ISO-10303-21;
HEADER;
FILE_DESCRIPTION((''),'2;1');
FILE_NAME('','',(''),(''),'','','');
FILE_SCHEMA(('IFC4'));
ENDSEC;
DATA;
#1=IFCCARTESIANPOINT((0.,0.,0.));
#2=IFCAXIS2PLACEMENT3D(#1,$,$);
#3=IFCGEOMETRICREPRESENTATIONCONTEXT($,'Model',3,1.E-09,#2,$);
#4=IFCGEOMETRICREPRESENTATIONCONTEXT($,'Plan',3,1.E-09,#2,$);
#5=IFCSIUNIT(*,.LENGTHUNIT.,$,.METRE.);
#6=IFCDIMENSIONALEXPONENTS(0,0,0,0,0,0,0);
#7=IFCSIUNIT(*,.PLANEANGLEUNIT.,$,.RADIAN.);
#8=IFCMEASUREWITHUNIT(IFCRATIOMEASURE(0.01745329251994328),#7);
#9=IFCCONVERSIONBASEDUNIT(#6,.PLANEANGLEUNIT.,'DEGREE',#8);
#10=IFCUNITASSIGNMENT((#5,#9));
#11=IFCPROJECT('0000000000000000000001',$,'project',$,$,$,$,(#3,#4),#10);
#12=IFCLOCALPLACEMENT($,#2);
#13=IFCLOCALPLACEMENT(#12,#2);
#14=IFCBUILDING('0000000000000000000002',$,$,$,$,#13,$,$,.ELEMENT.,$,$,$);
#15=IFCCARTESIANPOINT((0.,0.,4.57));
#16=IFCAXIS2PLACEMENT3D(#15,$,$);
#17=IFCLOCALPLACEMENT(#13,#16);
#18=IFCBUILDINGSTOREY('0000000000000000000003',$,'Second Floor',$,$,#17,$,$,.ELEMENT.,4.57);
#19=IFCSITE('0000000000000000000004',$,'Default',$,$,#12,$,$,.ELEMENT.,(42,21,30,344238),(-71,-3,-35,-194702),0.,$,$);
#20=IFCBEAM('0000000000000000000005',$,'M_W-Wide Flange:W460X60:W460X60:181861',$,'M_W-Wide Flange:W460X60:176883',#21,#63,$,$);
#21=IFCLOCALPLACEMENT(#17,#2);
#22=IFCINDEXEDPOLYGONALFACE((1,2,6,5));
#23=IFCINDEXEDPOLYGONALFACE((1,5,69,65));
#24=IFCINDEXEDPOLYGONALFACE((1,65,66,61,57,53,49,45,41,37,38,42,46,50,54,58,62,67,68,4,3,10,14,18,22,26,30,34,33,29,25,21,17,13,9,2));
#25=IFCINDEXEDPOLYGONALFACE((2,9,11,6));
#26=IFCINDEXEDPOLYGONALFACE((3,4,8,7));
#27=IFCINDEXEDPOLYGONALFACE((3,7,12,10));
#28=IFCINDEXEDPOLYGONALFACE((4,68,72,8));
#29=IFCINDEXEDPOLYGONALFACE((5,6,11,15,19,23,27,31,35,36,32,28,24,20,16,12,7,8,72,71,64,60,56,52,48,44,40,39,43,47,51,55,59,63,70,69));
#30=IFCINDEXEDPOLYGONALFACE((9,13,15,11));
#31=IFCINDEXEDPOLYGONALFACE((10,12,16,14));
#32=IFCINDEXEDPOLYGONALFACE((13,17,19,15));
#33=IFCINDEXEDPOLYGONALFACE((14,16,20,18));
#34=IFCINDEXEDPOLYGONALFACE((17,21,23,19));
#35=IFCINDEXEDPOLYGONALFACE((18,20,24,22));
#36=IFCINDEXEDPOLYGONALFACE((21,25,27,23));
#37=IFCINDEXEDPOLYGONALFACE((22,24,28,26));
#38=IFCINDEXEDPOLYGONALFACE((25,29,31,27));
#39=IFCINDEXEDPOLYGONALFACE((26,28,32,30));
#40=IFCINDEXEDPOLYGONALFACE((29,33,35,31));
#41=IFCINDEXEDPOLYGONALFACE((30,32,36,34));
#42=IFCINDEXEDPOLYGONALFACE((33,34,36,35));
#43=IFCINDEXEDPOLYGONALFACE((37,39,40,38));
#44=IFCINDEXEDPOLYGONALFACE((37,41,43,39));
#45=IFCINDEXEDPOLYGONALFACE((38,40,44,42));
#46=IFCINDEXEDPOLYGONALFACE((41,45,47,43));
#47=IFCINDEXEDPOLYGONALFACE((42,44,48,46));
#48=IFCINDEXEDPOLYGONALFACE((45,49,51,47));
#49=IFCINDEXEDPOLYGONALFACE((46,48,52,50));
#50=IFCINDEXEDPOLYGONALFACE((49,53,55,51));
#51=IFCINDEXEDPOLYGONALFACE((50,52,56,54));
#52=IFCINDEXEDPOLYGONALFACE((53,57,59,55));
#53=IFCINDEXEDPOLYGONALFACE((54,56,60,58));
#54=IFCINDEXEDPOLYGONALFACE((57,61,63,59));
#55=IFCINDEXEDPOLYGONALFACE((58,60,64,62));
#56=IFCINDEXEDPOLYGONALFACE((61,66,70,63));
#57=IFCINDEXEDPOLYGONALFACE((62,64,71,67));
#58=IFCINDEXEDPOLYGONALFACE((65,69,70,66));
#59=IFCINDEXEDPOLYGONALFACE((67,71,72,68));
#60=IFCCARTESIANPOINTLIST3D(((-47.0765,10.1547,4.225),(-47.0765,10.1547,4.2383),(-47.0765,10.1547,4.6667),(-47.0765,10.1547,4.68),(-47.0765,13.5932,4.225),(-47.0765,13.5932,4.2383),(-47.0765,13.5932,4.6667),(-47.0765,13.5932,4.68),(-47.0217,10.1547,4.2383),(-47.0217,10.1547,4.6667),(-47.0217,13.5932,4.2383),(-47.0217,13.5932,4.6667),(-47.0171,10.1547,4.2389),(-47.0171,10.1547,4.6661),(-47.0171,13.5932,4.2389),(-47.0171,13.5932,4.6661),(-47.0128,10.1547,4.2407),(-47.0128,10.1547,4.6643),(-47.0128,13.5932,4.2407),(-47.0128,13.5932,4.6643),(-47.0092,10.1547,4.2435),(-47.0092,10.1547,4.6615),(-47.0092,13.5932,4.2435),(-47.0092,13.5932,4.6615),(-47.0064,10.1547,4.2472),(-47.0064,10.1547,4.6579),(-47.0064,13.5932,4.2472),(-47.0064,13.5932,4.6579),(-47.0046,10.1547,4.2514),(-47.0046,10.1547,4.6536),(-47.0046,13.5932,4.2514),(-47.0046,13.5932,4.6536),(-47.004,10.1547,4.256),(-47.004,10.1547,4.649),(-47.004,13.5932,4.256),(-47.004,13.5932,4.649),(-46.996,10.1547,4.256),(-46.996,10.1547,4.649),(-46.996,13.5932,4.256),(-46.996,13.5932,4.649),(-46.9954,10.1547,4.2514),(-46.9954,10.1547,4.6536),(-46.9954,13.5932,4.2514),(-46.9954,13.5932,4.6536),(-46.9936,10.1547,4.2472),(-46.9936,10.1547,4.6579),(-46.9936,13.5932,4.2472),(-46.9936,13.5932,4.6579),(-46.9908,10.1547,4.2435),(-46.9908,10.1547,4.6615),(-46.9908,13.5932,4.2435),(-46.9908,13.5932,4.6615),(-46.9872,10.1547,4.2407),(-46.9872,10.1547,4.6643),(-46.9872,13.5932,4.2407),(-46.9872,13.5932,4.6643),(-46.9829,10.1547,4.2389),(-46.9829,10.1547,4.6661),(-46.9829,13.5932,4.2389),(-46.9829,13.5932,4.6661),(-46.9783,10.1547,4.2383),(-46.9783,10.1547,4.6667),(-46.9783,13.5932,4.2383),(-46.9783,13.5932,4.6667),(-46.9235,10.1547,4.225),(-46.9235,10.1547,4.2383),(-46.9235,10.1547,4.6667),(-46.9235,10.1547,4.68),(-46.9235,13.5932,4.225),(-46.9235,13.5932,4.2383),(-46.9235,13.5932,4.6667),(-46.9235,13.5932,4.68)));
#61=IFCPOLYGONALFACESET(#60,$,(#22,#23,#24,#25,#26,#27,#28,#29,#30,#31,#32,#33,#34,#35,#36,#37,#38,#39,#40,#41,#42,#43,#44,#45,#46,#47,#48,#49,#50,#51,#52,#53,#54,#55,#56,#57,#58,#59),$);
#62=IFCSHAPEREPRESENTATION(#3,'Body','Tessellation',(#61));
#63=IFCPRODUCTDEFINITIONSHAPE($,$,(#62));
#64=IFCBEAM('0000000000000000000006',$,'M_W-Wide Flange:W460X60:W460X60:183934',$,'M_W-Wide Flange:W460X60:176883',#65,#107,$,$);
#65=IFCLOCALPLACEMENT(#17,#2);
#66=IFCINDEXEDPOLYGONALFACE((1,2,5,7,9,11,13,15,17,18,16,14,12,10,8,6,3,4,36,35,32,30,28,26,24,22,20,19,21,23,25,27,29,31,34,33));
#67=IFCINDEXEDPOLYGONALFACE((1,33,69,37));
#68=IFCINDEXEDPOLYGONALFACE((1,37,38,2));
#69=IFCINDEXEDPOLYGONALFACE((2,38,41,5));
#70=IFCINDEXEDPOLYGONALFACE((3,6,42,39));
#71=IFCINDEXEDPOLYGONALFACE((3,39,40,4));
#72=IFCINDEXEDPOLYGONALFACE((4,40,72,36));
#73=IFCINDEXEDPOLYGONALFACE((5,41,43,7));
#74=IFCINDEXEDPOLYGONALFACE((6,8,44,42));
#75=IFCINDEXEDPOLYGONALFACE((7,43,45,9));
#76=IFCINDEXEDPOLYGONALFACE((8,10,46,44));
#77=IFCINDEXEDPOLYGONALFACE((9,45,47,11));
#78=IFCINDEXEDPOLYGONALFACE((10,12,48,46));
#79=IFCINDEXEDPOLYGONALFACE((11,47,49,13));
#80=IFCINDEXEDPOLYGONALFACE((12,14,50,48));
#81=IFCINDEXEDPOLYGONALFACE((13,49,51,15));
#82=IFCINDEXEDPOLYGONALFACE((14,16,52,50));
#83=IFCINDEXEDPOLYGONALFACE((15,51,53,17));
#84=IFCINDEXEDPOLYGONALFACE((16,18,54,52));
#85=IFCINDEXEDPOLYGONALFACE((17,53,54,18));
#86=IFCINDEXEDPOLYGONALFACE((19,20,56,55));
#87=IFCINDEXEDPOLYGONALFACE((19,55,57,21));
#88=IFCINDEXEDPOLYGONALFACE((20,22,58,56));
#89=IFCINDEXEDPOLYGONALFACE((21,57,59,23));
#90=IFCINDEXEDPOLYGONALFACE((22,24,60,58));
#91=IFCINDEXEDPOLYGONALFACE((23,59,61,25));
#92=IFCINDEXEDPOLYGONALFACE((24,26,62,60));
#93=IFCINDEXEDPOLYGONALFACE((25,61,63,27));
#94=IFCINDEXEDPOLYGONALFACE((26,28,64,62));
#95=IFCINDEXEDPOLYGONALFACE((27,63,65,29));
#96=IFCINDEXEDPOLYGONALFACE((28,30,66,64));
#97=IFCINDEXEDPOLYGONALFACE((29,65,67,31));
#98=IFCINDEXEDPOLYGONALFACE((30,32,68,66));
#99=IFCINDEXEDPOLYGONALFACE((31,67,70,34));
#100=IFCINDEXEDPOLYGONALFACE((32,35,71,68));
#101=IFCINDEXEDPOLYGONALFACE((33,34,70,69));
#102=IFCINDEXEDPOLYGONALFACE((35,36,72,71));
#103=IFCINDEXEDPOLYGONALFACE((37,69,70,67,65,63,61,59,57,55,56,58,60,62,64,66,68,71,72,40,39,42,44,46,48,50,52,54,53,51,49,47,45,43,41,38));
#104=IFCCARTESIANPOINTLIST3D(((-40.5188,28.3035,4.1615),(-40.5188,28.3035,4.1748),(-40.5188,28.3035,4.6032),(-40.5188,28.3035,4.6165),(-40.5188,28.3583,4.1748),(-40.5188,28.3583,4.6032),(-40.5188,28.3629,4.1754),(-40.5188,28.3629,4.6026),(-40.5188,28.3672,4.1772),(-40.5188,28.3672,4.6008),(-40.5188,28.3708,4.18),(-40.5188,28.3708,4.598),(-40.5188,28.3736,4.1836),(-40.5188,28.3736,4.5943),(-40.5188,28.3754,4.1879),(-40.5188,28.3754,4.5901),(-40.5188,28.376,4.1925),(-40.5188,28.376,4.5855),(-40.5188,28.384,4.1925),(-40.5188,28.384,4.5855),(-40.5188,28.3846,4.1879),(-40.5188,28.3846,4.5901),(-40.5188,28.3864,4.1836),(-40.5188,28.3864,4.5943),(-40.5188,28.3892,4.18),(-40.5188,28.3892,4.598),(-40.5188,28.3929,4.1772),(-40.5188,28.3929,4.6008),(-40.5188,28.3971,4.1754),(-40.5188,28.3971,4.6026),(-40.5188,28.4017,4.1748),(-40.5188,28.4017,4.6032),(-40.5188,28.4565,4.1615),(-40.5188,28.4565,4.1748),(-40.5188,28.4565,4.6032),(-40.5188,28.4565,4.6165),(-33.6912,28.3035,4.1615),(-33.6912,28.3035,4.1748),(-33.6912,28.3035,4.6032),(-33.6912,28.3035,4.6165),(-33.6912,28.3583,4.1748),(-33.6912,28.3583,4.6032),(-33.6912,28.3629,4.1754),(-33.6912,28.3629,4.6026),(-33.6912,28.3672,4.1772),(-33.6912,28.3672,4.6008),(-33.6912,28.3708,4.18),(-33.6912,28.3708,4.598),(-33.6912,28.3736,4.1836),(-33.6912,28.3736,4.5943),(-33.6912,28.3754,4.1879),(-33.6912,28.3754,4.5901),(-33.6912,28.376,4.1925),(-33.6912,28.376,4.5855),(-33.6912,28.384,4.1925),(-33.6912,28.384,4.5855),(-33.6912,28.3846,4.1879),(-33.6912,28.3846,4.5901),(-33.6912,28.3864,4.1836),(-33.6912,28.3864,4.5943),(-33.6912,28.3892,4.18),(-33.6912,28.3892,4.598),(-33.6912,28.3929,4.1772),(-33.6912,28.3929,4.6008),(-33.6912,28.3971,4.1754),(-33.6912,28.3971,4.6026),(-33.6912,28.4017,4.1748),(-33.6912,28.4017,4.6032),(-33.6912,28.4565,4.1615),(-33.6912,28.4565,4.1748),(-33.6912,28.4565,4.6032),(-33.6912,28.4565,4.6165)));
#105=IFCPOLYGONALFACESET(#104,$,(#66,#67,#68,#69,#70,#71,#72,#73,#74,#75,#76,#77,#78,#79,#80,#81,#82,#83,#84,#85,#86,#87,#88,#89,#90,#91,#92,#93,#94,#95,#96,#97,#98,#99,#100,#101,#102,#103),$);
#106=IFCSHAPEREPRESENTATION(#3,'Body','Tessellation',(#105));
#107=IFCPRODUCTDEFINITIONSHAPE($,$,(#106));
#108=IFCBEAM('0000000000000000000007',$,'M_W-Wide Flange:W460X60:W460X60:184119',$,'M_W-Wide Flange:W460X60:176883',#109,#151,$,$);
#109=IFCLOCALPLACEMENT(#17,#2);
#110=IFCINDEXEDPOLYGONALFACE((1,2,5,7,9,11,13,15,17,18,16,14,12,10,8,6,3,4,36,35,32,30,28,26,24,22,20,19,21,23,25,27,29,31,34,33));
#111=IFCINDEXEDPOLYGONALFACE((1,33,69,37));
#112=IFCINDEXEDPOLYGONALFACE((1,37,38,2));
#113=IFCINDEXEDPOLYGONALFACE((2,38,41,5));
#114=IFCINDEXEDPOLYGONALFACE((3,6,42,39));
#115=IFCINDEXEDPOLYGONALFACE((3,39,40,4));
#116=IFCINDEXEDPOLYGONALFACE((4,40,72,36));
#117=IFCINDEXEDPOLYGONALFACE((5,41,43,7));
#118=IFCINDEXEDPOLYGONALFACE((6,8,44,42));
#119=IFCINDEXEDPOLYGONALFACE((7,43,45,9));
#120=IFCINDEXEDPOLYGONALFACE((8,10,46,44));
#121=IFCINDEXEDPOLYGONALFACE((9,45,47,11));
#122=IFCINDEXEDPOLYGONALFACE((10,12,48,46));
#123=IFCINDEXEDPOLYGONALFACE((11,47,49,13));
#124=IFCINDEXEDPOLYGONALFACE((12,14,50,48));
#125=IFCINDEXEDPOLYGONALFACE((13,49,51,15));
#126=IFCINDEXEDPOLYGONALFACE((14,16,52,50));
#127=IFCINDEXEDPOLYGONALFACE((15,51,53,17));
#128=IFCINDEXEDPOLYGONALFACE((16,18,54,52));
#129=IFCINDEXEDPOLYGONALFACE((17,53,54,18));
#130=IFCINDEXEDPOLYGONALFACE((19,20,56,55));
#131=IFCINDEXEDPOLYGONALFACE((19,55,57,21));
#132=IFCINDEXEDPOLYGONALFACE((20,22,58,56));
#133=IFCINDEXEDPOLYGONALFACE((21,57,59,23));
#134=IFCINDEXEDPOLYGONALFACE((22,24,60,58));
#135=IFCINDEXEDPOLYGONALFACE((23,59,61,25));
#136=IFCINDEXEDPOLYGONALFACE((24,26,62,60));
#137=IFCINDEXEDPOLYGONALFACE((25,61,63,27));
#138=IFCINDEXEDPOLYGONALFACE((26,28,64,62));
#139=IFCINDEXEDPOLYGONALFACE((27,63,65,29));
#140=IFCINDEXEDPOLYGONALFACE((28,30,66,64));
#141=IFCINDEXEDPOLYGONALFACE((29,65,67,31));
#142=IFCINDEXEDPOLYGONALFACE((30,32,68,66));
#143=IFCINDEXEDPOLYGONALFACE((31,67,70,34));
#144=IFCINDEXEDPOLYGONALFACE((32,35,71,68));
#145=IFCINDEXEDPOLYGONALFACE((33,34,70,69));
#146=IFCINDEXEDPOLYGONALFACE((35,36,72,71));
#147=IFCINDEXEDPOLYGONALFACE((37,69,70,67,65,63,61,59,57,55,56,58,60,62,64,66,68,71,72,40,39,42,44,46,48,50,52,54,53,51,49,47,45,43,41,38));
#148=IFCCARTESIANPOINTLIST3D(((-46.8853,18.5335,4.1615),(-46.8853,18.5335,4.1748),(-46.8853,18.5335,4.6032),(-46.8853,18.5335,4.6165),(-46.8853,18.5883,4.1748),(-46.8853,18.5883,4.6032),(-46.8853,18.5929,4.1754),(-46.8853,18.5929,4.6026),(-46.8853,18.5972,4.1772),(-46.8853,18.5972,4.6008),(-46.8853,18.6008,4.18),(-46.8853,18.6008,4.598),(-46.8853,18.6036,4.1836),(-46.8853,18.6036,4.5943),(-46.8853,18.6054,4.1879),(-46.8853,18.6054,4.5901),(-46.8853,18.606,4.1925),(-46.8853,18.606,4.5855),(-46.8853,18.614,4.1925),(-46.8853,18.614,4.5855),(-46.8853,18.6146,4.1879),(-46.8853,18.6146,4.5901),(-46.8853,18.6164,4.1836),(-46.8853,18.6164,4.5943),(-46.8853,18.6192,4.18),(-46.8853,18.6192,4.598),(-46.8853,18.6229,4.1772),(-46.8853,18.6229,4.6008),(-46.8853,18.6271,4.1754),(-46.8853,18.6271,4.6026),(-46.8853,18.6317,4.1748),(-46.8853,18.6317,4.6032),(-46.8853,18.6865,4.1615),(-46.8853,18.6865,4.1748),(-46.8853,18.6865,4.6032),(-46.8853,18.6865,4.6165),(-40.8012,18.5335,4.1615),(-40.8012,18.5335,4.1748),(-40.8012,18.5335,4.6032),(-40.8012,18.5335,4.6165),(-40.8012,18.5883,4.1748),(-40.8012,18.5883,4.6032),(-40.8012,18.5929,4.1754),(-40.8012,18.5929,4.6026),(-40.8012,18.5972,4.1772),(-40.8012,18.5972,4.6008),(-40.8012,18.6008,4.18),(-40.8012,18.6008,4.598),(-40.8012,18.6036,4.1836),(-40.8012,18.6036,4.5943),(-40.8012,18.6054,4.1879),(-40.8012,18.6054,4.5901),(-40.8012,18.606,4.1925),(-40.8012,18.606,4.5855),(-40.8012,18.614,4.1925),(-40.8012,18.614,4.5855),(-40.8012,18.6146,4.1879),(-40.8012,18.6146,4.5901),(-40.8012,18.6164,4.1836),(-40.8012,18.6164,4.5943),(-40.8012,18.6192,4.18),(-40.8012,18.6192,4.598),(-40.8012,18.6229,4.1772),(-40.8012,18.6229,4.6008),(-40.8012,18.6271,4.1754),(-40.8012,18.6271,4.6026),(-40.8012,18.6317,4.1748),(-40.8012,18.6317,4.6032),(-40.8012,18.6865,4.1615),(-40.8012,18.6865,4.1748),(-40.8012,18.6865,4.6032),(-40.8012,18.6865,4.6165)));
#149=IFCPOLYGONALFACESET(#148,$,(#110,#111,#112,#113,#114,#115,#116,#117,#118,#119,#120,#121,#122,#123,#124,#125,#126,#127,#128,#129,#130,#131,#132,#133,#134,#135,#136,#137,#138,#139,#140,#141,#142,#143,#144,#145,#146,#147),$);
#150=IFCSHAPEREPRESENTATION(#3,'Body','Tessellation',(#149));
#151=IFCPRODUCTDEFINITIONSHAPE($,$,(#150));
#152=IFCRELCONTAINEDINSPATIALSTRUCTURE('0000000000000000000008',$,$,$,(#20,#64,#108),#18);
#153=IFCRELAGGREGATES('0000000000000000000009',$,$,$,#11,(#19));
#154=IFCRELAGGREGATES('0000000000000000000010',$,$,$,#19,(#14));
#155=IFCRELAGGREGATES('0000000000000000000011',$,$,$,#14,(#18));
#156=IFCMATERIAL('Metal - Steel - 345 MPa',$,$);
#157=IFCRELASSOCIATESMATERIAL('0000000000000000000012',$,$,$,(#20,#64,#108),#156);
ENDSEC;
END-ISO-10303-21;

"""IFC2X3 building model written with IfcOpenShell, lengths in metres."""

from ifc_helpers import new_model, entity, si_unit, converted_unit, frame, frame_2d, origin, place, context, project, spatial, polyline, circle_curve, parameter, trimmed, segment, composite_curve, outline, extrude, material, element, save


model = new_model("IFC2X3")

# Units and contexts
model_context = context("Model", 3, precision=1e-09, world=origin())
plan_context = context("Plan", 3, precision=1e-09, world=origin())
ifc_project = project(units=[si_unit("LENGTHUNIT", "METRE"), converted_unit("PLANEANGLEUNIT", "DEGREE", entity("IfcRatioMeasure", 0.01745329251994328), si_unit("PLANEANGLEUNIT", "RADIAN"), dimensions=[0, 0, 0, 0, 0, 0, 0])], contexts=[model_context, plan_context])

# Site, building, storey
site_placement = place(None, origin())
site = spatial("IfcSite", under=ifc_project, at=site_placement, Name="Default", CompositionType="ELEMENT", RefLatitude=(42, 21, 30, 344238), RefLongitude=(-71, -3, -35, -194702), RefElevation=0.0)
building_placement = place(site_placement, origin())
building = spatial("IfcBuilding", under=site, at=building_placement, CompositionType="ELEMENT")
storey_placement = place(building_placement, frame((0.0, 0.0, 4.57)))
storey = spatial("IfcBuildingStorey", under=building, at=storey_placement, Name="Second Floor", CompositionType="ELEMENT", Elevation=4.57)

# Shared definitions
ifc_material_1 = material(Name="Metal - Steel - 345 MPa")

# Beams
beam_1_placement = place(storey_placement, frame((-47.0, 13.7293, 4.68), z_axis=(0.0, 0.0, 1.0), x_axis=(-1.0, 0.0, 0.0)))
element("IfcBeam", 1, at=beam_1_placement, inside=storey, material=ifc_material_1, Name="M_W-Wide Flange:W460X60:W460X60:181861", ObjectType="M_W-Wide Flange:W460X60:176883", context=model_context, shape_type="SweptSolid", body=[
    extrude(outline(composite_curve([segment(polyline([(0.2142, -0.0765), (0.2275, -0.0765)]), True, "CONTINUOUS"), segment(polyline([(0.2275, -0.0765), (0.2275, 0.0765)]), True, "CONTINUOUS"), segment(polyline([(0.2275, 0.0765), (0.2142, 0.0765)]), True, "CONTINUOUS"), segment(polyline([(0.2142, 0.0765), (0.2142, 0.0217)]), True, "CONTINUOUS"), segment(trimmed(circle_curve(frame_2d((0.1965, 0.0217), x_axis=(0.0, 1.0)), 0.0177), [parameter(180.0)], [parameter(270.0)], True, "PARAMETER"), False, "CONTINUOUS"), segment(polyline([(0.1965, 0.004), (-0.1965, 0.004)]), True, "CONTINUOUS"), segment(trimmed(circle_curve(frame_2d((-0.1965, 0.0217), x_axis=(0.0, 1.0)), 0.0177), [parameter(90.0)], [parameter(180.0)], True, "PARAMETER"), False, "CONTINUOUS"), segment(polyline([(-0.2142, 0.0217), (-0.2142, 0.0765)]), True, "CONTINUOUS"), segment(polyline([(-0.2142, 0.0765), (-0.2275, 0.0765)]), True, "CONTINUOUS"), segment(polyline([(-0.2275, 0.0765), (-0.2275, -0.0765)]), True, "CONTINUOUS"), segment(polyline([(-0.2275, -0.0765), (-0.2142, -0.0765)]), True, "CONTINUOUS"), segment(polyline([(-0.2142, -0.0765), (-0.2142, -0.0217)]), True, "CONTINUOUS"), segment(trimmed(circle_curve(frame_2d((-0.1965, -0.0217), x_axis=(0.0, 1.0)), 0.0177), [parameter(360.0)], [parameter(90.0)], True, "PARAMETER"), False, "CONTINUOUS"), segment(polyline([(-0.1965, -0.004), (0.1965, -0.004)]), True, "CONTINUOUS"), segment(trimmed(circle_curve(frame_2d((0.1965, -0.0217), x_axis=(0.0, 1.0)), 0.0177), [parameter(270.0)], [parameter(0.0)], True, "PARAMETER"), False, "CONTINUOUS"), segment(polyline([(0.2142, -0.0217), (0.2142, -0.0765)]), True, "CONTINUOUS")], self_intersect=False)), frame((0.0, 3.5746, -0.2275), z_axis=(0.0, -1.0, 0.0), x_axis=(0.0, 0.0, -1.0)), (0.0, 0.0, 1.0), 3.4385),
])
beam_2_placement = place(storey_placement, frame((-40.6573, 28.38, 4.6165), z_axis=(0.0, 0.0, 1.0), x_axis=(0.0, -1.0, 0.0)))
element("IfcBeam", 2, at=beam_2_placement, inside=storey, material=ifc_material_1, Name="M_W-Wide Flange:W460X60:W460X60:183934", ObjectType="M_W-Wide Flange:W460X60:176883", context=model_context, shape_type="SweptSolid", body=[
    extrude(outline(composite_curve([segment(polyline([(-0.0765, -0.2142), (-0.0765, -0.2275)]), True, "CONTINUOUS"), segment(polyline([(-0.0765, -0.2275), (0.0765, -0.2275)]), True, "CONTINUOUS"), segment(polyline([(0.0765, -0.2275), (0.0765, -0.2142)]), True, "CONTINUOUS"), segment(polyline([(0.0765, -0.2142), (0.0217, -0.2142)]), True, "CONTINUOUS"), segment(trimmed(circle_curve(frame_2d((0.0217, -0.1965), x_axis=(0.0, -1.0)), 0.0177), [parameter(270.0)], [parameter(360.0)], True, "PARAMETER"), False, "CONTINUOUS"), segment(polyline([(0.004, -0.1965), (0.004, 0.1965)]), True, "CONTINUOUS"), segment(trimmed(circle_curve(frame_2d((0.0217, 0.1965), x_axis=(-1.0, 0.0)), 0.0177), [parameter(270.0)], [parameter(360.0)], True, "PARAMETER"), False, "CONTINUOUS"), segment(polyline([(0.0217, 0.2142), (0.0765, 0.2142)]), True, "CONTINUOUS"), segment(polyline([(0.0765, 0.2142), (0.0765, 0.2275)]), True, "CONTINUOUS"), segment(polyline([(0.0765, 0.2275), (-0.0765, 0.2275)]), True, "CONTINUOUS"), segment(polyline([(-0.0765, 0.2275), (-0.0765, 0.2142)]), True, "CONTINUOUS"), segment(polyline([(-0.0765, 0.2142), (-0.0217, 0.2142)]), True, "CONTINUOUS"), segment(trimmed(circle_curve(frame_2d((-0.0217, 0.1965), x_axis=(0.0, 1.0)), 0.0177), [parameter(270.0)], [parameter(360.0)], True, "PARAMETER"), False, "CONTINUOUS"), segment(polyline([(-0.004, 0.1965), (-0.004, -0.1965)]), True, "CONTINUOUS"), segment(trimmed(circle_curve(frame_2d((-0.0217, -0.1965), x_axis=(1.0, 0.0)), 0.0177), [parameter(270.0)], [parameter(0.0)], True, "PARAMETER"), False, "CONTINUOUS"), segment(polyline([(-0.0217, -0.2142), (-0.0765, -0.2142)]), True, "CONTINUOUS")], self_intersect=False)), frame((0.0, 0.1385, -0.2275), z_axis=(0.0, -1.0, 0.0), x_axis=(1.0, 0.0, 0.0)), (0.0, 0.0, -1.0), 6.8276),
])
beam_3_placement = place(storey_placement, frame((-40.663, 18.61, 4.6165), z_axis=(0.0, 0.0, 1.0), x_axis=(0.0, 1.0, 0.0)))
element("IfcBeam", 3, at=beam_3_placement, inside=storey, material=ifc_material_1, Name="M_W-Wide Flange:W460X60:W460X60:184119", ObjectType="M_W-Wide Flange:W460X60:176883", context=model_context, shape_type="SweptSolid", body=[
    extrude(outline(composite_curve([segment(polyline([(0.2142, -0.0765), (0.2275, -0.0765)]), True, "CONTINUOUS"), segment(polyline([(0.2275, -0.0765), (0.2275, 0.0765)]), True, "CONTINUOUS"), segment(polyline([(0.2275, 0.0765), (0.2142, 0.0765)]), True, "CONTINUOUS"), segment(polyline([(0.2142, 0.0765), (0.2142, 0.0217)]), True, "CONTINUOUS"), segment(trimmed(circle_curve(frame_2d((0.1965, 0.0217), x_axis=(0.0, 1.0)), 0.0177), [parameter(180.0)], [parameter(270.0)], True, "PARAMETER"), False, "CONTINUOUS"), segment(polyline([(0.1965, 0.004), (-0.1965, 0.004)]), True, "CONTINUOUS"), segment(trimmed(circle_curve(frame_2d((-0.1965, 0.0217), x_axis=(0.0, 1.0)), 0.0177), [parameter(90.0)], [parameter(180.0)], True, "PARAMETER"), False, "CONTINUOUS"), segment(polyline([(-0.2142, 0.0217), (-0.2142, 0.0765)]), True, "CONTINUOUS"), segment(polyline([(-0.2142, 0.0765), (-0.2275, 0.0765)]), True, "CONTINUOUS"), segment(polyline([(-0.2275, 0.0765), (-0.2275, -0.0765)]), True, "CONTINUOUS"), segment(polyline([(-0.2275, -0.0765), (-0.2142, -0.0765)]), True, "CONTINUOUS"), segment(polyline([(-0.2142, -0.0765), (-0.2142, -0.0217)]), True, "CONTINUOUS"), segment(trimmed(circle_curve(frame_2d((-0.1965, -0.0217), x_axis=(0.0, 1.0)), 0.0177), [parameter(360.0)], [parameter(90.0)], True, "PARAMETER"), False, "CONTINUOUS"), segment(polyline([(-0.1965, -0.004), (0.1965, -0.004)]), True, "CONTINUOUS"), segment(trimmed(circle_curve(frame_2d((0.1965, -0.0217), x_axis=(0.0, 1.0)), 0.0177), [parameter(270.0)], [parameter(0.0)], True, "PARAMETER"), False, "CONTINUOUS"), segment(polyline([(0.2142, -0.0217), (0.2142, -0.0765)]), True, "CONTINUOUS")], self_intersect=False)), frame((0.0, 6.2223, -0.2275), z_axis=(0.0, -1.0, 0.0), x_axis=(0.0, 0.0, -1.0)), (0.0, 0.0, 1.0), 6.0841),
])

save(model, "model.ifc")
